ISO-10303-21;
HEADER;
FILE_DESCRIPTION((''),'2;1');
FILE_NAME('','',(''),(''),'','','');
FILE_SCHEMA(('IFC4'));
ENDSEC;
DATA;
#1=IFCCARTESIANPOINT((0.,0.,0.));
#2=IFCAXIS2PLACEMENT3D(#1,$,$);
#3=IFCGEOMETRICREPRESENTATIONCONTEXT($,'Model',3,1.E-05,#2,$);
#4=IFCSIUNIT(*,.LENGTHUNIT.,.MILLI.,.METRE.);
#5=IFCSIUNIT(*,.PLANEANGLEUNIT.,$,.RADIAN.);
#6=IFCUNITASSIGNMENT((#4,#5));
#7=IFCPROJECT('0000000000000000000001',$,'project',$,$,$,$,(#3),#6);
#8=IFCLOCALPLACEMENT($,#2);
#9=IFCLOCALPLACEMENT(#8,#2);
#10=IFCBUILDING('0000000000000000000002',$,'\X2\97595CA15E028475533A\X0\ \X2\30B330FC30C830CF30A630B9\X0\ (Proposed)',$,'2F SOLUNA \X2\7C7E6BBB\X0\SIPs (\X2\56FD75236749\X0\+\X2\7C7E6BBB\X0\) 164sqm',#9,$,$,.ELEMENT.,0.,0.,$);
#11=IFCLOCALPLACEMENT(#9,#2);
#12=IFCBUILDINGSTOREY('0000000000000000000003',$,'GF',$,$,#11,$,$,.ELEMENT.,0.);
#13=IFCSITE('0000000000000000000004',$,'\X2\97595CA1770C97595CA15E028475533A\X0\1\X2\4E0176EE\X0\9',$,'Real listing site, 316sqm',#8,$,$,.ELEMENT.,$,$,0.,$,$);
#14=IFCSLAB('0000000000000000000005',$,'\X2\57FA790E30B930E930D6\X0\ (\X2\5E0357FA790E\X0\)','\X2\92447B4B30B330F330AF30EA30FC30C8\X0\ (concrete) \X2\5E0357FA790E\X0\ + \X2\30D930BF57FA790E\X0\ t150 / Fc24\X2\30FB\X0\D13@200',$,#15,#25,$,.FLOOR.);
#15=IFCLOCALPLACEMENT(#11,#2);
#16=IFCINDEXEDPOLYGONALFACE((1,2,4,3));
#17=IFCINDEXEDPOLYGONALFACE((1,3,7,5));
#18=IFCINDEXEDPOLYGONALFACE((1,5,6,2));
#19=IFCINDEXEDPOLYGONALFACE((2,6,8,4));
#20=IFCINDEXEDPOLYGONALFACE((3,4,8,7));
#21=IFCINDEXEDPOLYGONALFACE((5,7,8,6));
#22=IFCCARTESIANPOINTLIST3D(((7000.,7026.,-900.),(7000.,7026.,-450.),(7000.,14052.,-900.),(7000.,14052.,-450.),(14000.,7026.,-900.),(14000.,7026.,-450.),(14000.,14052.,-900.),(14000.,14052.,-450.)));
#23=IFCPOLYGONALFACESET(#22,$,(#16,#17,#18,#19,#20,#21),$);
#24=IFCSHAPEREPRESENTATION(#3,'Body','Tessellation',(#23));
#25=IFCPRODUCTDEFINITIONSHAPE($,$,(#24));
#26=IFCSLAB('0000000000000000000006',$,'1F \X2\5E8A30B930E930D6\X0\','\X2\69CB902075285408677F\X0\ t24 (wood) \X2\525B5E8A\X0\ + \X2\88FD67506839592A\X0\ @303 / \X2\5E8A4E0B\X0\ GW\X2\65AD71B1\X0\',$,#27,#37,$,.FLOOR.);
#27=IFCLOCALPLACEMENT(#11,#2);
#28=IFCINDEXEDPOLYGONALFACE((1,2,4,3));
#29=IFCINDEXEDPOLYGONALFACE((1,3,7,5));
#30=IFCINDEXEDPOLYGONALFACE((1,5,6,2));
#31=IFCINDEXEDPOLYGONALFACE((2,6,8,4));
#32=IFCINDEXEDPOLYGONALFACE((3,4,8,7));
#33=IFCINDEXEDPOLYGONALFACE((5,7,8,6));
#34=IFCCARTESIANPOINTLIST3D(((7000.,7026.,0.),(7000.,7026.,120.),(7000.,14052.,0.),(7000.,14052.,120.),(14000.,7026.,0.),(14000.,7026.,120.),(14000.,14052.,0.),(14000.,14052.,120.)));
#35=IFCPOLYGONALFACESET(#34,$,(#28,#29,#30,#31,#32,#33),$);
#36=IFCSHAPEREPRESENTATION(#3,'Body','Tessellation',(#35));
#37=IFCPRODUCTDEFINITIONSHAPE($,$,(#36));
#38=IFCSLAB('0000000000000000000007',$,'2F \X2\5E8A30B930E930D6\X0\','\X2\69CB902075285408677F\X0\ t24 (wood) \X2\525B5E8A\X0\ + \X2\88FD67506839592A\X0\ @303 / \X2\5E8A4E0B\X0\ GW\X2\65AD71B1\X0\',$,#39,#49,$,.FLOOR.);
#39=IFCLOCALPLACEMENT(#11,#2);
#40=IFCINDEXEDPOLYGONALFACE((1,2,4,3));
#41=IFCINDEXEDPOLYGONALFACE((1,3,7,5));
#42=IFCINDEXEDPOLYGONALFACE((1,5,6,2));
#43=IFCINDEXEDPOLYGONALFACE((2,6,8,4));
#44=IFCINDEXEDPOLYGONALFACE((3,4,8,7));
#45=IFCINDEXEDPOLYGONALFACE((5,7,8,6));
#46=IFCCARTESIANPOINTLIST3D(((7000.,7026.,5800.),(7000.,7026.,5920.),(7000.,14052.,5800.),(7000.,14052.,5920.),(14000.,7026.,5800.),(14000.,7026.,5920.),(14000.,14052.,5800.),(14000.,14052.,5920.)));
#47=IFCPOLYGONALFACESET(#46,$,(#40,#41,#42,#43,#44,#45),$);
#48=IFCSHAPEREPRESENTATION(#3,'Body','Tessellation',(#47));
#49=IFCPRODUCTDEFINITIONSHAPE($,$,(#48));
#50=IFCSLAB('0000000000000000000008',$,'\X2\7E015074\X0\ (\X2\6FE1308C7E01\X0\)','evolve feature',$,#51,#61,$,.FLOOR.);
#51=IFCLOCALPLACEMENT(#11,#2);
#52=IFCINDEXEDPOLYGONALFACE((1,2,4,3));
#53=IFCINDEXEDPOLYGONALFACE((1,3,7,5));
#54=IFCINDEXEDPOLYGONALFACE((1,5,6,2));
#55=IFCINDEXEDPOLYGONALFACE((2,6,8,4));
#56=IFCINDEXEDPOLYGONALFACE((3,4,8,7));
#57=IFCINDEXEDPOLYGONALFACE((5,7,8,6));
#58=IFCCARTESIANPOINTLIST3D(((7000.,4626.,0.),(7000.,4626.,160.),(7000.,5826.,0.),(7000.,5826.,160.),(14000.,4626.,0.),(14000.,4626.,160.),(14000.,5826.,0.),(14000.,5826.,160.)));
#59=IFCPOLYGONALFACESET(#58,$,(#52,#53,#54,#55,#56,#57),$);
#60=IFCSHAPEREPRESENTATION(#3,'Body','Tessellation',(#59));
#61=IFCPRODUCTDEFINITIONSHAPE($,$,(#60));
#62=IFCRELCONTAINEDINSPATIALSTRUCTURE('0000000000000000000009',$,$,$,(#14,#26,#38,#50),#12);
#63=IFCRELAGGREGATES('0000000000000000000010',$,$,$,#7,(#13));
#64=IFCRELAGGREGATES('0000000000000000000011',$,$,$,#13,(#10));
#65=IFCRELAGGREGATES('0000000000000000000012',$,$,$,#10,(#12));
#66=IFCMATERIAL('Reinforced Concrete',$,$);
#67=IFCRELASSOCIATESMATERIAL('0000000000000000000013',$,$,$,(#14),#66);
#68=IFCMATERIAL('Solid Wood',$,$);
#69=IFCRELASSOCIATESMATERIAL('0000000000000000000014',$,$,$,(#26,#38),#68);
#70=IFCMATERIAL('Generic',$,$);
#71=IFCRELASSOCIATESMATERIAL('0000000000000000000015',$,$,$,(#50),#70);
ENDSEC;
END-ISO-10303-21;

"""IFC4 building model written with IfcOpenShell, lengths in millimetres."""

from ifc_helpers import new_model, si_unit, frame, frame_2d, origin, place, context, project, spatial, rectangle, extrude, material, element, save


model = new_model("IFC4")

# Units and contexts
model_context = context("Model", 3, precision=1e-05, world=origin())
ifc_project = project(units=[si_unit("LENGTHUNIT", "METRE", prefix="MILLI"), si_unit("PLANEANGLEUNIT", "RADIAN")], contexts=[model_context])

# Site, building, storey
site_placement = place(None, origin())
site = spatial("IfcSite", under=ifc_project, at=site_placement, Name="静岡県静岡市葵区1丁目9", ObjectType="Real listing site, 316sqm", CompositionType="ELEMENT", RefElevation=0.0)
building_placement = place(site_placement, origin())
building = spatial("IfcBuilding", under=site, at=building_placement, Name="静岡市葵区 コートハウス (Proposed)", ObjectType="2F SOLUNA 籾殻SIPs (国産杉+籾殻) 164sqm", CompositionType="ELEMENT", ElevationOfRefHeight=0.0, ElevationOfTerrain=0.0)
storey_placement = place(building_placement, origin())
storey = spatial("IfcBuildingStorey", under=building, at=storey_placement, Name="GF", CompositionType="ELEMENT", Elevation=0.0)

# Slabs
ifc_material_1 = material(Name="Reinforced Concrete")
slab_1_placement = place(storey_placement, frame((3500.0, 3513.0, -450.0)))
element("IfcSlab", 1, at=slab_1_placement, inside=storey, material=ifc_material_1, Name="基礎スラブ (布基礎)", Description="鉄筋コンクリート (concrete) 布基礎 + ベタ基礎 t150 / Fc24・D13@200", PredefinedType="FLOOR", context=model_context, shape_type="SweptSolid", body=[
    extrude(rectangle(XDim=7000.0, YDim=7026.0, at=frame_2d((3500.0, 3513.0))), frame((3500.0, 3513.0, -450.0)), (0.0, 0.0, 1.0), 450.0),
])
ifc_material_2 = material(Name="Solid Wood")
slab_2_placement = place(storey_placement, frame((3500.0, 3513.0, 0.0)))
element("IfcSlab", 2, at=slab_2_placement, inside=storey, material=ifc_material_2, Name="1F 床スラブ", Description="構造用合板 t24 (wood) 剛床 + 製材根太 @303 / 床下 GW断熱", PredefinedType="FLOOR", context=model_context, shape_type="SweptSolid", body=[
    extrude(rectangle(XDim=7000.0, YDim=7026.0, at=frame_2d((3500.0, 3513.0))), frame((3500.0, 3513.0, 0.0)), (0.0, 0.0, 1.0), 120.0),
])
slab_3_placement = place(storey_placement, frame((3500.0, 3513.0, 2900.0)))
element("IfcSlab", 3, at=slab_3_placement, inside=storey, material=ifc_material_2, Name="2F 床スラブ", Description="構造用合板 t24 (wood) 剛床 + 製材根太 @303 / 床下 GW断熱", PredefinedType="FLOOR", context=model_context, shape_type="SweptSolid", body=[
    extrude(rectangle(XDim=7000.0, YDim=7026.0, at=frame_2d((3500.0, 3513.0))), frame((3500.0, 3513.0, 2900.0)), (0.0, 0.0, 1.0), 120.0),
])
ifc_material_3 = material(Name="Generic")
slab_4_placement = place(storey_placement, frame((3500.0, 2313.0, 0.0)))
element("IfcSlab", 4, at=slab_4_placement, inside=storey, material=ifc_material_3, Name="縁側 (濡れ縁)", Description="evolve feature", PredefinedType="FLOOR", context=model_context, shape_type="SweptSolid", body=[
    extrude(rectangle(XDim=7000.0, YDim=1200.0, at=frame_2d((3500.0, 600.0))), frame((3500.0, 2313.0, 0.0)), (0.0, 0.0, 1.0), 160.0),
])

save(model, "model.ifc")
